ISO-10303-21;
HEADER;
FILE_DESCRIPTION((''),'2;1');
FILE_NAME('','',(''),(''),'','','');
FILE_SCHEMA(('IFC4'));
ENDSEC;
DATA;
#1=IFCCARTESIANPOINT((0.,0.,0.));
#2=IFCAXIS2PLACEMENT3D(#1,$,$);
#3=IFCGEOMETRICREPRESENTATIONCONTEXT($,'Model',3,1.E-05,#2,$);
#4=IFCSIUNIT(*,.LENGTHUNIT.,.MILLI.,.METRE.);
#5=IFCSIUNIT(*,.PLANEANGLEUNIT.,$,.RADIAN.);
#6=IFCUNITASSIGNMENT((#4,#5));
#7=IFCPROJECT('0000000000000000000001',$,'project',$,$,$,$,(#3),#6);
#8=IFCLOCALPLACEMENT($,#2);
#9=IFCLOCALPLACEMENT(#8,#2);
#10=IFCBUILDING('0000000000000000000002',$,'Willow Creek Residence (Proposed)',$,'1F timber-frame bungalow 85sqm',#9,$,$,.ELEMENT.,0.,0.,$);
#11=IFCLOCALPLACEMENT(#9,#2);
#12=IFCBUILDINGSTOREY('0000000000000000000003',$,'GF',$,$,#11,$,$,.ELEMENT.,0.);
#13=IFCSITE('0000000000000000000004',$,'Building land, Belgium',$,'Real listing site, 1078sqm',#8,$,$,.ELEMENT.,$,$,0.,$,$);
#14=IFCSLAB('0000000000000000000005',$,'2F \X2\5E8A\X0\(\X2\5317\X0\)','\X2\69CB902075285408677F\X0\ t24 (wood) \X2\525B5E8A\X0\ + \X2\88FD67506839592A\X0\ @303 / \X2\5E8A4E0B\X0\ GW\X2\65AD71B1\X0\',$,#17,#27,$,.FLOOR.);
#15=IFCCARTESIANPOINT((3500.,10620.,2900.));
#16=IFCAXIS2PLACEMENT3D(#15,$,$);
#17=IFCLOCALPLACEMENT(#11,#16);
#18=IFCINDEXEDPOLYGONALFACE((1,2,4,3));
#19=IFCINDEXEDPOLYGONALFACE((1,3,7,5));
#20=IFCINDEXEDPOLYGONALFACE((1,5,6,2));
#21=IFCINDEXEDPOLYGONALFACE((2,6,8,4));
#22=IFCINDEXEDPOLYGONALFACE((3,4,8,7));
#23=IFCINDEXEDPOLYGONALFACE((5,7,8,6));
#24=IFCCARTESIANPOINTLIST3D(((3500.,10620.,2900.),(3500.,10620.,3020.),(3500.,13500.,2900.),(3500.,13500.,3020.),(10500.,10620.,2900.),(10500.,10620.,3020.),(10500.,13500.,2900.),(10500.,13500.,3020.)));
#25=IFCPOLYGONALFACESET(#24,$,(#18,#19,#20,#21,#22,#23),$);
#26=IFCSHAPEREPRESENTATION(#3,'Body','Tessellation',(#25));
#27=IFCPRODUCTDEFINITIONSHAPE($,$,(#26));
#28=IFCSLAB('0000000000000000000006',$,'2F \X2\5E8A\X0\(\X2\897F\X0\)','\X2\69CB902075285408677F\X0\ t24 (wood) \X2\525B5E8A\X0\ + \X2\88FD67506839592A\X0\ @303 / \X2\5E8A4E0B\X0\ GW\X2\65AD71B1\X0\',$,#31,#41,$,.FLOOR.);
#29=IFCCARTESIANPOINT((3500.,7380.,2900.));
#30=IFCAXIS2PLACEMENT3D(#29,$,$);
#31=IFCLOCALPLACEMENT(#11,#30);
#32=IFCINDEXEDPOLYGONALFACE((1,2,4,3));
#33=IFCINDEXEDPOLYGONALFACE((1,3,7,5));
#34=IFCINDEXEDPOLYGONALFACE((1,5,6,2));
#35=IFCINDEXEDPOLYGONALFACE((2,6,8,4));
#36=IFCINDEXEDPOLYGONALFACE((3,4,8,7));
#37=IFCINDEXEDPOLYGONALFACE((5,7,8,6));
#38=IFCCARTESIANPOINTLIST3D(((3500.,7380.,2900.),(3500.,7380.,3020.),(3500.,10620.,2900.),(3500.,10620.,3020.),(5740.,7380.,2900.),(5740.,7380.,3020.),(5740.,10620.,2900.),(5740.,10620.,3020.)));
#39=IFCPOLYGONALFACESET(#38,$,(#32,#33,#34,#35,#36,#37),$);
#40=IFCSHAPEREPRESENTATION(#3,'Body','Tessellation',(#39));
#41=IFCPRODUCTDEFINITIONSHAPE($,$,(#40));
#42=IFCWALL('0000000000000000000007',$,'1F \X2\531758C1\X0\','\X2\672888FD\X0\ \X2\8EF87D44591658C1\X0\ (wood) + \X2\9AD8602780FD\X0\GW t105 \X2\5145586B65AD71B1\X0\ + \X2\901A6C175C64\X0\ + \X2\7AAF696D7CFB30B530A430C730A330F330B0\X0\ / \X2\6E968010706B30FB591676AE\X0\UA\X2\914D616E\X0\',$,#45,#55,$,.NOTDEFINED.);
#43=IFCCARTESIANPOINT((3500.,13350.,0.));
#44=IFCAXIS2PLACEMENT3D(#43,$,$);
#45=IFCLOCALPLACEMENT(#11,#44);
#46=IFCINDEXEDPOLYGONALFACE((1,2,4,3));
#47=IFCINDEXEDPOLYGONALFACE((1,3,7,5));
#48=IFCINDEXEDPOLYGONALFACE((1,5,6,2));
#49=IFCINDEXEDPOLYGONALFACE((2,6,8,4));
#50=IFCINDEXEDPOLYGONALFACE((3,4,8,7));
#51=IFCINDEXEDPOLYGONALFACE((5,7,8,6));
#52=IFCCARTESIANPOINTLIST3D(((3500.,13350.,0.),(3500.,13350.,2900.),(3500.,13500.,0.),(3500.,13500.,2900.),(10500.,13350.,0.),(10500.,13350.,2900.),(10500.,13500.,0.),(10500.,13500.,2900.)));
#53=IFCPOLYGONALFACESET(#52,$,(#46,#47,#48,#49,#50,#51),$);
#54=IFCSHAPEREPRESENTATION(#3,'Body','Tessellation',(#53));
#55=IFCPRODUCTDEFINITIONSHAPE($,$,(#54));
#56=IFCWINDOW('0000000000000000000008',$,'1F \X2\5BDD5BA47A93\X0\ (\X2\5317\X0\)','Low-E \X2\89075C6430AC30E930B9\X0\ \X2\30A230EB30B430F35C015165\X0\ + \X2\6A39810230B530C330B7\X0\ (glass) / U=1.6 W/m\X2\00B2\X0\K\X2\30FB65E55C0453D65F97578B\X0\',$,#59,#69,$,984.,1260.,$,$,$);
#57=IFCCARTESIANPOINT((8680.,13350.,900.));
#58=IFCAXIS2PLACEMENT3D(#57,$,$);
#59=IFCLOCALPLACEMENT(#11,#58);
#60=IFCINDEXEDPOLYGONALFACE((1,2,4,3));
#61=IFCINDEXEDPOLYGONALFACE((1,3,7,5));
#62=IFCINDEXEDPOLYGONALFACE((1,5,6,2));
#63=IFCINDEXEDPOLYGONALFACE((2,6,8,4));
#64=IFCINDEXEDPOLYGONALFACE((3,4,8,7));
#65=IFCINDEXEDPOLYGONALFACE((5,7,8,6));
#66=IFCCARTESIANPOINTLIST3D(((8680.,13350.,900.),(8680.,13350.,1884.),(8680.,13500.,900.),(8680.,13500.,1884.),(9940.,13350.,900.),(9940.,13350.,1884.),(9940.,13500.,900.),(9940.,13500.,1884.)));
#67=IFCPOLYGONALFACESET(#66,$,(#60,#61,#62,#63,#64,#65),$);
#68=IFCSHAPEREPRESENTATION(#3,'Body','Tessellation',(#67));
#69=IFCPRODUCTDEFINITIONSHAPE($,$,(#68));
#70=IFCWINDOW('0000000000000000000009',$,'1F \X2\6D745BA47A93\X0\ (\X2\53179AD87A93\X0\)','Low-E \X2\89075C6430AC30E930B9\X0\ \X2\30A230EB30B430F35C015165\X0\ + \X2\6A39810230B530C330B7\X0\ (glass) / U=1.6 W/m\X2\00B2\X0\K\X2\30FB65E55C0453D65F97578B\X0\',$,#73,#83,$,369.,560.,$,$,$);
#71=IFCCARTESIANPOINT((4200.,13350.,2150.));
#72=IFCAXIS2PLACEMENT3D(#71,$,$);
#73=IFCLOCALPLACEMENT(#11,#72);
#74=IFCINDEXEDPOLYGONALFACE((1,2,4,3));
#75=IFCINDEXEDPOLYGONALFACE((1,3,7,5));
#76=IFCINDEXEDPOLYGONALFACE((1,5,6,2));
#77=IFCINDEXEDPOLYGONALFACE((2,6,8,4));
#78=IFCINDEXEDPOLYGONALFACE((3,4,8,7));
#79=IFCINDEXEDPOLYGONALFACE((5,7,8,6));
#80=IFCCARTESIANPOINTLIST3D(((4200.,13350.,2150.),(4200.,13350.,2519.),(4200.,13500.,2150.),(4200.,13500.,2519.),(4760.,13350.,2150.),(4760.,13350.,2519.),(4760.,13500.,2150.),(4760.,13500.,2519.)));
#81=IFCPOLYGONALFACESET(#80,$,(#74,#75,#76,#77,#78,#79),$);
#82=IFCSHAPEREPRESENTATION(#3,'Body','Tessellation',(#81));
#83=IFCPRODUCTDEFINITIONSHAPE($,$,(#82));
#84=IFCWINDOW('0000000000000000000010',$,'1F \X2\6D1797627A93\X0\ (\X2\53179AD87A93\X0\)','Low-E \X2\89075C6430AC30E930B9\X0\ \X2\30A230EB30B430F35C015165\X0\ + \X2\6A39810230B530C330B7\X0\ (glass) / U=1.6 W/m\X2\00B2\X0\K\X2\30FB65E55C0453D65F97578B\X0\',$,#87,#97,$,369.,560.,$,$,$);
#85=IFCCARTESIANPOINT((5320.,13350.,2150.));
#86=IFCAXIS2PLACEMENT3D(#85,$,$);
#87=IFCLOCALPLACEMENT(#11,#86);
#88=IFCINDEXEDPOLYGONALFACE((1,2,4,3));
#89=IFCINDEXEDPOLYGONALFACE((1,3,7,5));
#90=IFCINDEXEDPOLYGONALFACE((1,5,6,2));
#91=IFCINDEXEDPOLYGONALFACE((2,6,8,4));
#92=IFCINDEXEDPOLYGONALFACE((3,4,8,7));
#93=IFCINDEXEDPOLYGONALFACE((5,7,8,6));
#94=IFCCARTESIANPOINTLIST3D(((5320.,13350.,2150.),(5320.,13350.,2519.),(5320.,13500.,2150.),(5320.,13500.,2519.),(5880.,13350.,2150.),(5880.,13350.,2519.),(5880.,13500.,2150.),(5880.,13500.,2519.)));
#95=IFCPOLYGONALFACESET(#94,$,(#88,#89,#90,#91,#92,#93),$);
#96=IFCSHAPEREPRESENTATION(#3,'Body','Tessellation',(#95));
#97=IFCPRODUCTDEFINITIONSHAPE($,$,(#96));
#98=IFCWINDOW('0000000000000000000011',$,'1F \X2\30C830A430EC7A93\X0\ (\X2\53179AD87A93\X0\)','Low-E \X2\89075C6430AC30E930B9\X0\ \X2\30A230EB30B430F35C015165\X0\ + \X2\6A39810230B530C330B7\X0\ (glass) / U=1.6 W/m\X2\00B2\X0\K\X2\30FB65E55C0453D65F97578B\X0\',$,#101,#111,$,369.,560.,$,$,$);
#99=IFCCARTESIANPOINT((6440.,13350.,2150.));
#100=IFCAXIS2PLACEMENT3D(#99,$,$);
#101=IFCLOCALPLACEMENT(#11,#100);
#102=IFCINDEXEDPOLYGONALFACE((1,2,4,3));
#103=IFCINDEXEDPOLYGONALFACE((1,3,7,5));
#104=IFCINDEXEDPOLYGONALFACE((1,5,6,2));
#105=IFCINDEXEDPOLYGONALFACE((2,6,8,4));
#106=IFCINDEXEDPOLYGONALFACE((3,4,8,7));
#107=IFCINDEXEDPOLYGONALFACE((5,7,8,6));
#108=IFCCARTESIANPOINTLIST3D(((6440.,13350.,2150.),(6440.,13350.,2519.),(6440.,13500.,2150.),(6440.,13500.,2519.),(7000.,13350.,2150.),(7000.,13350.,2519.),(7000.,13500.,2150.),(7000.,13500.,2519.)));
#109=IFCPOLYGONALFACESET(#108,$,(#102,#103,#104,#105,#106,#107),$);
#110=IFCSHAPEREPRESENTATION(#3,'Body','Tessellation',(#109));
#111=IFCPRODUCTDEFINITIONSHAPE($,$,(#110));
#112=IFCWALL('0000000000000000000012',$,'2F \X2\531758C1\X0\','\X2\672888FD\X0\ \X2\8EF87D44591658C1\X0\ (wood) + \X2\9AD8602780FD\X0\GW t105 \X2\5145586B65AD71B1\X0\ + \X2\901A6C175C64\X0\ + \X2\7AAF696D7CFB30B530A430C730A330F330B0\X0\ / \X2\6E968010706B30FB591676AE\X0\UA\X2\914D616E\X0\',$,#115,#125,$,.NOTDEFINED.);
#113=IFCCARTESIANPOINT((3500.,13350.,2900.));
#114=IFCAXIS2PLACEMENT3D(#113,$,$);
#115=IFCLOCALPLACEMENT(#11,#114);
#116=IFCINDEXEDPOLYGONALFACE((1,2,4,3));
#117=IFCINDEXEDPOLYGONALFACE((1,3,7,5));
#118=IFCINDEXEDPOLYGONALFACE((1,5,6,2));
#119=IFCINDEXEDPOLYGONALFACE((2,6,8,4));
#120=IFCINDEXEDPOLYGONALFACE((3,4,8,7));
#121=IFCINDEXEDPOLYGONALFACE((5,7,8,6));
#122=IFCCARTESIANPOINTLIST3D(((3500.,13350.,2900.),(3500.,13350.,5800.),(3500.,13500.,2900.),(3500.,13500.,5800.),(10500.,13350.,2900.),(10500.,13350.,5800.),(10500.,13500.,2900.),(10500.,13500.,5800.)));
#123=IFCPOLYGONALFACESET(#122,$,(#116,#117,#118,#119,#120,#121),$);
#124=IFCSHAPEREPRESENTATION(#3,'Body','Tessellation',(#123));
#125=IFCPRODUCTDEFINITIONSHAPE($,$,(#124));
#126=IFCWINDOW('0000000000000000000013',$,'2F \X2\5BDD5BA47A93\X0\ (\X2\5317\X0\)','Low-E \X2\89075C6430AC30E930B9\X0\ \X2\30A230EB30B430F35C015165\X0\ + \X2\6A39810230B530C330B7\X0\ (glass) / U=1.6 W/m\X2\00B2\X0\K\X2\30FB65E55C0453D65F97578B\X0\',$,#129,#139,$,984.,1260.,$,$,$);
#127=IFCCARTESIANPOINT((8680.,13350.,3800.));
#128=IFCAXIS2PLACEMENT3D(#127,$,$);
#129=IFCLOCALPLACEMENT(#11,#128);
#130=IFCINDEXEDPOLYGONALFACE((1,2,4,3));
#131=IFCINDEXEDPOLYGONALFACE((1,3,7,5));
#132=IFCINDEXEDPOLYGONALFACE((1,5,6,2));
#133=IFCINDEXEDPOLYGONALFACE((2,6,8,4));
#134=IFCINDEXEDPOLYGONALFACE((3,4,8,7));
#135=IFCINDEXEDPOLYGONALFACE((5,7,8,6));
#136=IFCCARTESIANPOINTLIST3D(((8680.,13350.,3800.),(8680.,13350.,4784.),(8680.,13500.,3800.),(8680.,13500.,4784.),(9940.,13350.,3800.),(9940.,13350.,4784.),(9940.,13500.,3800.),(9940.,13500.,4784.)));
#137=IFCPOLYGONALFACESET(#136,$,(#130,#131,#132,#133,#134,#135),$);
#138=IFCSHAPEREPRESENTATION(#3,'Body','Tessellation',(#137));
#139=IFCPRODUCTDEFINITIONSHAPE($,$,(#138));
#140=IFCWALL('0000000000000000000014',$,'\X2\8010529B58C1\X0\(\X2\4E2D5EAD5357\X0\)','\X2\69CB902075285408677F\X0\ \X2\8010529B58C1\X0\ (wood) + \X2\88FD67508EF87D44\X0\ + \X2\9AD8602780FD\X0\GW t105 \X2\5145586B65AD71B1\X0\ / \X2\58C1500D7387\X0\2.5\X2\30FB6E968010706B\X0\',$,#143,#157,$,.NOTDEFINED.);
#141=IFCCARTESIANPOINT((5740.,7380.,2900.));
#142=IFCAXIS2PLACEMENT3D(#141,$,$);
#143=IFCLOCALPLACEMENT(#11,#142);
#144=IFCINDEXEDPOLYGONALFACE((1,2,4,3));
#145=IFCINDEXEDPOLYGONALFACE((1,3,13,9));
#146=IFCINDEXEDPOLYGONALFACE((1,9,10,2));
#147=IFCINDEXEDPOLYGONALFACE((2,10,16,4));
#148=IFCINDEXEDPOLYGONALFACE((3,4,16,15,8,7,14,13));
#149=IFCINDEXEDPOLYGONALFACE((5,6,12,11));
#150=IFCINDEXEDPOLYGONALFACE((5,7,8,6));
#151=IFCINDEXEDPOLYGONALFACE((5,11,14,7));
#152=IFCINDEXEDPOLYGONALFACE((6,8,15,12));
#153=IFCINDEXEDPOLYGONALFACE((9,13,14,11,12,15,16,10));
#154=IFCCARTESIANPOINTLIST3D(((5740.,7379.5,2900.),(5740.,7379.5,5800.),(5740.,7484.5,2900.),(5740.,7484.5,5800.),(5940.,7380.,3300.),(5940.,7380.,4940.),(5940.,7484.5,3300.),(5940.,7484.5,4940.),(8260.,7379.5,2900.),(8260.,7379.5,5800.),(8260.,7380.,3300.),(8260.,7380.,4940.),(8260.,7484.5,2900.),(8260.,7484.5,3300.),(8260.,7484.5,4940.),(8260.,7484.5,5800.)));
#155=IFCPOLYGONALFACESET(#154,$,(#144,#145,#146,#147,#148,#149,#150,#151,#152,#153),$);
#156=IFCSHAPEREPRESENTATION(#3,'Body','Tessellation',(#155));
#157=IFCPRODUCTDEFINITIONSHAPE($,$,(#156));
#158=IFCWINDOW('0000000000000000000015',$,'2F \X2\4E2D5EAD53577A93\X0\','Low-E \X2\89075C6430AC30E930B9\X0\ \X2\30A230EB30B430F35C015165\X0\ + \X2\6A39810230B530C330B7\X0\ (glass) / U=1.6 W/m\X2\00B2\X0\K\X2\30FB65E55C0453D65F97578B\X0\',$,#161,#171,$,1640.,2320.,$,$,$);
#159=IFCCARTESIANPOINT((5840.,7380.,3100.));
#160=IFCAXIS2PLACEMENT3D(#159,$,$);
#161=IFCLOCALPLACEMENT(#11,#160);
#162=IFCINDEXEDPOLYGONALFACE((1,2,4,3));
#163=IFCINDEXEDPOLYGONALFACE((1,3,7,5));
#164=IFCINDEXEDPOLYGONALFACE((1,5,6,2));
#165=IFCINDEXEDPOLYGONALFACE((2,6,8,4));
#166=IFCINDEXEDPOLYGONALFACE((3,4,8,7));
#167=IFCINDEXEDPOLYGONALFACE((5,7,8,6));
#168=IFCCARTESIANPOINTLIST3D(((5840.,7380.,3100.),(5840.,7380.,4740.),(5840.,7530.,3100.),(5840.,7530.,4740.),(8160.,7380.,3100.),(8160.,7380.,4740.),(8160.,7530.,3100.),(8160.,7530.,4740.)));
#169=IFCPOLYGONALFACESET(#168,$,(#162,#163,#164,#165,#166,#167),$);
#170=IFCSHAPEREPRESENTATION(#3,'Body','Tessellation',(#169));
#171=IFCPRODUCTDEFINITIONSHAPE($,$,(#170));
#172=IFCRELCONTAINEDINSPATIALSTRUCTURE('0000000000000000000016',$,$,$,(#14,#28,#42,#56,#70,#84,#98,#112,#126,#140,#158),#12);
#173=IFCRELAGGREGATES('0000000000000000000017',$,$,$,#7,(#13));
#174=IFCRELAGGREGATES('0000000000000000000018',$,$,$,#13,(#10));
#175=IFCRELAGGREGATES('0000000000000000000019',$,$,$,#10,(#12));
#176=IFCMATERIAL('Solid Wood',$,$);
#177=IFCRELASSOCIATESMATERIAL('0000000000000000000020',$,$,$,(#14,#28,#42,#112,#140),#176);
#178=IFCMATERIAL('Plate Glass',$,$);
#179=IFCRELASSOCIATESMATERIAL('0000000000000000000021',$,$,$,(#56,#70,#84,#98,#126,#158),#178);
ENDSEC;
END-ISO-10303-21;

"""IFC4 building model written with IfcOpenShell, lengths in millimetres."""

from ifc_helpers import new_model, si_unit, frame, frame_2d, origin, place, context, project, spatial, rectangle, extrude, material, element, fill, save


model = new_model("IFC4")

# Units and contexts
model_context = context("Model", 3, precision=1e-05, world=origin())
ifc_project = project(units=[si_unit("LENGTHUNIT", "METRE", prefix="MILLI"), si_unit("PLANEANGLEUNIT", "RADIAN")], contexts=[model_context])

# Site, building, storey
site_placement = place(None, origin())
site = spatial("IfcSite", under=ifc_project, at=site_placement, Name="Building land, Belgium", ObjectType="Real listing site, 1078sqm", CompositionType="ELEMENT", RefElevation=0.0)
building_placement = place(site_placement, origin())
building = spatial("IfcBuilding", under=site, at=building_placement, Name="Willow Creek Residence (Proposed)", ObjectType="1F timber-frame bungalow 85sqm", CompositionType="ELEMENT", ElevationOfRefHeight=0.0, ElevationOfTerrain=0.0)
storey_placement = place(building_placement, origin())
storey = spatial("IfcBuildingStorey", under=building, at=storey_placement, Name="GF", CompositionType="ELEMENT", Elevation=0.0)

# Slabs
ifc_material_1 = material(Name="Solid Wood")
slab_1_placement = place(storey_placement, frame((3500.0, 10620.0, 2900.0)))
element("IfcSlab", 1, at=slab_1_placement, inside=storey, material=ifc_material_1, Name="2F 床(北)", Description="構造用合板 t24 (wood) 剛床 + 製材根太 @303 / 床下 GW断熱", PredefinedType="FLOOR", context=model_context, shape_type="SweptSolid", body=[
    extrude(rectangle(XDim=7000.0, YDim=2880.0, at=frame_2d((3500.0, 1440.0))), frame((3500.0, 10620.0, 2900.0)), (0.0, 0.0, 1.0), 120.0),
])
slab_2_placement = place(storey_placement, frame((3500.0, 7380.0, 2900.0)))
element("IfcSlab", 2, at=slab_2_placement, inside=storey, material=ifc_material_1, Name="2F 床(西)", Description="構造用合板 t24 (wood) 剛床 + 製材根太 @303 / 床下 GW断熱", PredefinedType="FLOOR", context=model_context, shape_type="SweptSolid", body=[
    extrude(rectangle(XDim=2240.0, YDim=3240.0, at=frame_2d((1120.0, 1620.0))), frame((3500.0, 7380.0, 2900.0)), (0.0, 0.0, 1.0), 120.0),
])

# Wall, openings, windows
wall_1_placement = place(storey_placement, frame((3500.0, 13350.0, 0.0)))
wall_1 = element("IfcWall", 3, at=wall_1_placement, inside=storey, material=ifc_material_1, Name="1F 北壁", Description="木製 軸組外壁 (wood) + 高性能GW t105 充填断熱 + 通気層 + 窯業系サイディング / 準耐火・外皮UA配慮", PredefinedType="NOTDEFINED", context=model_context, shape_type="SweptSolid", body=[
    extrude(rectangle(XDim=7000.0, YDim=150.0, at=frame_2d((3500.0, 75.0))), frame((3500.0, 13350.0, 0.0)), (0.0, 0.0, 1.0), 2900.0),
])
opening_1_placement = place(storey_placement, frame((8680.0, 13350.0, 900.0)))
opening_1 = element("IfcOpeningElement", 4, at=opening_1_placement, cuts=wall_1, PredefinedType="NOTDEFINED", context=model_context, shape_type="SweptSolid", body=[
    extrude(rectangle(XDim=1260.0, YDim=150.0, at=frame_2d((630.0, 75.0))), frame((8680.0, 13350.0, 900.0)), (0.0, 0.0, 1.0), 984.0),
])
opening_2_placement = place(storey_placement, frame((4200.0, 13350.0, 2150.0)))
opening_2 = element("IfcOpeningElement", 5, at=opening_2_placement, cuts=wall_1, PredefinedType="NOTDEFINED", context=model_context, shape_type="SweptSolid", body=[
    extrude(rectangle(XDim=560.0, YDim=150.0, at=frame_2d((280.0, 75.0))), frame((4200.0, 13350.0, 2150.0)), (0.0, 0.0, 1.0), 369.0),
])
opening_3_placement = place(storey_placement, frame((5320.0, 13350.0, 2150.0)))
opening_3 = element("IfcOpeningElement", 6, at=opening_3_placement, cuts=wall_1, PredefinedType="NOTDEFINED", context=model_context, shape_type="SweptSolid", body=[
    extrude(rectangle(XDim=560.0, YDim=150.0, at=frame_2d((280.0, 75.0))), frame((5320.0, 13350.0, 2150.0)), (0.0, 0.0, 1.0), 369.0),
])
opening_4_placement = place(storey_placement, frame((6440.0, 13350.0, 2150.0)))
opening_4 = element("IfcOpeningElement", 7, at=opening_4_placement, cuts=wall_1, PredefinedType="NOTDEFINED", context=model_context, shape_type="SweptSolid", body=[
    extrude(rectangle(XDim=560.0, YDim=150.0, at=frame_2d((280.0, 75.0))), frame((6440.0, 13350.0, 2150.0)), (0.0, 0.0, 1.0), 369.0),
])
ifc_material_2 = material(Name="Plate Glass")
window_1_placement = place(storey_placement, frame((8680.0, 13350.0, 900.0)))
window_1 = element("IfcWindow", 8, at=window_1_placement, inside=storey, material=ifc_material_2, Name="1F 寝室窓 (北)", Description="Low-E 複層ガラス アルゴン封入 + 樹脂サッシ (glass) / U=1.6 W/m²K・日射取得型", OverallHeight=984.0, OverallWidth=1260.0, context=model_context, shape_type="SweptSolid", body=[
    extrude(rectangle(XDim=1260.0, YDim=150.0, at=frame_2d((630.0, 75.0))), frame((8680.0, 13350.0, 900.0)), (0.0, 0.0, 1.0), 984.0),
])
fill(opening_1, window_1)
window_2_placement = place(storey_placement, frame((4200.0, 13350.0, 2150.0)))
window_2 = element("IfcWindow", 9, at=window_2_placement, inside=storey, material=ifc_material_2, Name="1F 浴室窓 (北高窓)", Description="Low-E 複層ガラス アルゴン封入 + 樹脂サッシ (glass) / U=1.6 W/m²K・日射取得型", OverallHeight=369.0, OverallWidth=560.0, context=model_context, shape_type="SweptSolid", body=[
    extrude(rectangle(XDim=560.0, YDim=150.0, at=frame_2d((280.0, 75.0))), frame((4200.0, 13350.0, 2150.0)), (0.0, 0.0, 1.0), 369.0),
])
fill(opening_2, window_2)
window_3_placement = place(storey_placement, frame((5320.0, 13350.0, 2150.0)))
window_3 = element("IfcWindow", 10, at=window_3_placement, inside=storey, material=ifc_material_2, Name="1F 洗面窓 (北高窓)", Description="Low-E 複層ガラス アルゴン封入 + 樹脂サッシ (glass) / U=1.6 W/m²K・日射取得型", OverallHeight=369.0, OverallWidth=560.0, context=model_context, shape_type="SweptSolid", body=[
    extrude(rectangle(XDim=560.0, YDim=150.0, at=frame_2d((280.0, 75.0))), frame((5320.0, 13350.0, 2150.0)), (0.0, 0.0, 1.0), 369.0),
])
fill(opening_3, window_3)
window_4_placement = place(storey_placement, frame((6440.0, 13350.0, 2150.0)))
window_4 = element("IfcWindow", 11, at=window_4_placement, inside=storey, material=ifc_material_2, Name="1F トイレ窓 (北高窓)", Description="Low-E 複層ガラス アルゴン封入 + 樹脂サッシ (glass) / U=1.6 W/m²K・日射取得型", OverallHeight=369.0, OverallWidth=560.0, context=model_context, shape_type="SweptSolid", body=[
    extrude(rectangle(XDim=560.0, YDim=150.0, at=frame_2d((280.0, 75.0))), frame((6440.0, 13350.0, 2150.0)), (0.0, 0.0, 1.0), 369.0),
])
fill(opening_4, window_4)

# Walls, openings, windows
wall_2_placement = place(storey_placement, frame((3500.0, 13350.0, 2900.0)))
wall_2 = element("IfcWall", 12, at=wall_2_placement, inside=storey, material=ifc_material_1, Name="2F 北壁", Description="木製 軸組外壁 (wood) + 高性能GW t105 充填断熱 + 通気層 + 窯業系サイディング / 準耐火・外皮UA配慮", PredefinedType="NOTDEFINED", context=model_context, shape_type="SweptSolid", body=[
    extrude(rectangle(XDim=7000.0, YDim=150.0, at=frame_2d((3500.0, 75.0))), frame((3500.0, 13350.0, 2900.0)), (0.0, 0.0, 1.0), 2900.0),
])
opening_5_placement = place(storey_placement, frame((8680.0, 13350.0, 3800.0)))
opening_5 = element("IfcOpeningElement", 13, at=opening_5_placement, cuts=wall_2, PredefinedType="NOTDEFINED", context=model_context, shape_type="SweptSolid", body=[
    extrude(rectangle(XDim=1260.0, YDim=150.0, at=frame_2d((630.0, 75.0))), frame((8680.0, 13350.0, 3800.0)), (0.0, 0.0, 1.0), 984.0),
])
window_5_placement = place(storey_placement, frame((8680.0, 13350.0, 3800.0)))
window_5 = element("IfcWindow", 14, at=window_5_placement, inside=storey, material=ifc_material_2, Name="2F 寝室窓 (北)", Description="Low-E 複層ガラス アルゴン封入 + 樹脂サッシ (glass) / U=1.6 W/m²K・日射取得型", OverallHeight=984.0, OverallWidth=1260.0, context=model_context, shape_type="SweptSolid", body=[
    extrude(rectangle(XDim=1260.0, YDim=150.0, at=frame_2d((630.0, 75.0))), frame((8680.0, 13350.0, 3800.0)), (0.0, 0.0, 1.0), 984.0),
])
fill(opening_5, window_5)
wall_3_placement = place(storey_placement, frame((5740.0, 7380.0, 2900.0)))
wall_3 = element("IfcWall", 15, at=wall_3_placement, inside=storey, material=ifc_material_1, Name="耐力壁(中庭南)", Description="構造用合板 耐力壁 (wood) + 製材軸組 + 高性能GW t105 充填断熱 / 壁倍率2.5・準耐火", PredefinedType="NOTDEFINED", context=model_context, shape_type="SweptSolid", body=[
    extrude(rectangle(XDim=2520.0, YDim=105.0, at=frame_2d((1260.0, 52.0))), frame((5740.0, 7380.0, 2900.0)), (0.0, 0.0, 1.0), 2900.0),
])
opening_6_placement = place(storey_placement, frame((5840.0, 7380.0, 3100.0)))
opening_6 = element("IfcOpeningElement", 16, at=opening_6_placement, cuts=wall_3, PredefinedType="NOTDEFINED", context=model_context, shape_type="SweptSolid", body=[
    extrude(rectangle(XDim=2320.0, YDim=150.0, at=frame_2d((1160.0, 75.0))), frame((5840.0, 7380.0, 3100.0)), (0.0, 0.0, 1.0), 1640.0),
])
window_6_placement = place(storey_placement, frame((5840.0, 7380.0, 3100.0)))
window_6 = element("IfcWindow", 17, at=window_6_placement, inside=storey, material=ifc_material_2, Name="2F 中庭南窓", Description="Low-E 複層ガラス アルゴン封入 + 樹脂サッシ (glass) / U=1.6 W/m²K・日射取得型", OverallHeight=1640.0, OverallWidth=2320.0, context=model_context, shape_type="SweptSolid", body=[
    extrude(rectangle(XDim=2320.0, YDim=150.0, at=frame_2d((1160.0, 75.0))), frame((5840.0, 7380.0, 3100.0)), (0.0, 0.0, 1.0), 1640.0),
])
fill(opening_6, window_6)

save(model, "model.ifc")
